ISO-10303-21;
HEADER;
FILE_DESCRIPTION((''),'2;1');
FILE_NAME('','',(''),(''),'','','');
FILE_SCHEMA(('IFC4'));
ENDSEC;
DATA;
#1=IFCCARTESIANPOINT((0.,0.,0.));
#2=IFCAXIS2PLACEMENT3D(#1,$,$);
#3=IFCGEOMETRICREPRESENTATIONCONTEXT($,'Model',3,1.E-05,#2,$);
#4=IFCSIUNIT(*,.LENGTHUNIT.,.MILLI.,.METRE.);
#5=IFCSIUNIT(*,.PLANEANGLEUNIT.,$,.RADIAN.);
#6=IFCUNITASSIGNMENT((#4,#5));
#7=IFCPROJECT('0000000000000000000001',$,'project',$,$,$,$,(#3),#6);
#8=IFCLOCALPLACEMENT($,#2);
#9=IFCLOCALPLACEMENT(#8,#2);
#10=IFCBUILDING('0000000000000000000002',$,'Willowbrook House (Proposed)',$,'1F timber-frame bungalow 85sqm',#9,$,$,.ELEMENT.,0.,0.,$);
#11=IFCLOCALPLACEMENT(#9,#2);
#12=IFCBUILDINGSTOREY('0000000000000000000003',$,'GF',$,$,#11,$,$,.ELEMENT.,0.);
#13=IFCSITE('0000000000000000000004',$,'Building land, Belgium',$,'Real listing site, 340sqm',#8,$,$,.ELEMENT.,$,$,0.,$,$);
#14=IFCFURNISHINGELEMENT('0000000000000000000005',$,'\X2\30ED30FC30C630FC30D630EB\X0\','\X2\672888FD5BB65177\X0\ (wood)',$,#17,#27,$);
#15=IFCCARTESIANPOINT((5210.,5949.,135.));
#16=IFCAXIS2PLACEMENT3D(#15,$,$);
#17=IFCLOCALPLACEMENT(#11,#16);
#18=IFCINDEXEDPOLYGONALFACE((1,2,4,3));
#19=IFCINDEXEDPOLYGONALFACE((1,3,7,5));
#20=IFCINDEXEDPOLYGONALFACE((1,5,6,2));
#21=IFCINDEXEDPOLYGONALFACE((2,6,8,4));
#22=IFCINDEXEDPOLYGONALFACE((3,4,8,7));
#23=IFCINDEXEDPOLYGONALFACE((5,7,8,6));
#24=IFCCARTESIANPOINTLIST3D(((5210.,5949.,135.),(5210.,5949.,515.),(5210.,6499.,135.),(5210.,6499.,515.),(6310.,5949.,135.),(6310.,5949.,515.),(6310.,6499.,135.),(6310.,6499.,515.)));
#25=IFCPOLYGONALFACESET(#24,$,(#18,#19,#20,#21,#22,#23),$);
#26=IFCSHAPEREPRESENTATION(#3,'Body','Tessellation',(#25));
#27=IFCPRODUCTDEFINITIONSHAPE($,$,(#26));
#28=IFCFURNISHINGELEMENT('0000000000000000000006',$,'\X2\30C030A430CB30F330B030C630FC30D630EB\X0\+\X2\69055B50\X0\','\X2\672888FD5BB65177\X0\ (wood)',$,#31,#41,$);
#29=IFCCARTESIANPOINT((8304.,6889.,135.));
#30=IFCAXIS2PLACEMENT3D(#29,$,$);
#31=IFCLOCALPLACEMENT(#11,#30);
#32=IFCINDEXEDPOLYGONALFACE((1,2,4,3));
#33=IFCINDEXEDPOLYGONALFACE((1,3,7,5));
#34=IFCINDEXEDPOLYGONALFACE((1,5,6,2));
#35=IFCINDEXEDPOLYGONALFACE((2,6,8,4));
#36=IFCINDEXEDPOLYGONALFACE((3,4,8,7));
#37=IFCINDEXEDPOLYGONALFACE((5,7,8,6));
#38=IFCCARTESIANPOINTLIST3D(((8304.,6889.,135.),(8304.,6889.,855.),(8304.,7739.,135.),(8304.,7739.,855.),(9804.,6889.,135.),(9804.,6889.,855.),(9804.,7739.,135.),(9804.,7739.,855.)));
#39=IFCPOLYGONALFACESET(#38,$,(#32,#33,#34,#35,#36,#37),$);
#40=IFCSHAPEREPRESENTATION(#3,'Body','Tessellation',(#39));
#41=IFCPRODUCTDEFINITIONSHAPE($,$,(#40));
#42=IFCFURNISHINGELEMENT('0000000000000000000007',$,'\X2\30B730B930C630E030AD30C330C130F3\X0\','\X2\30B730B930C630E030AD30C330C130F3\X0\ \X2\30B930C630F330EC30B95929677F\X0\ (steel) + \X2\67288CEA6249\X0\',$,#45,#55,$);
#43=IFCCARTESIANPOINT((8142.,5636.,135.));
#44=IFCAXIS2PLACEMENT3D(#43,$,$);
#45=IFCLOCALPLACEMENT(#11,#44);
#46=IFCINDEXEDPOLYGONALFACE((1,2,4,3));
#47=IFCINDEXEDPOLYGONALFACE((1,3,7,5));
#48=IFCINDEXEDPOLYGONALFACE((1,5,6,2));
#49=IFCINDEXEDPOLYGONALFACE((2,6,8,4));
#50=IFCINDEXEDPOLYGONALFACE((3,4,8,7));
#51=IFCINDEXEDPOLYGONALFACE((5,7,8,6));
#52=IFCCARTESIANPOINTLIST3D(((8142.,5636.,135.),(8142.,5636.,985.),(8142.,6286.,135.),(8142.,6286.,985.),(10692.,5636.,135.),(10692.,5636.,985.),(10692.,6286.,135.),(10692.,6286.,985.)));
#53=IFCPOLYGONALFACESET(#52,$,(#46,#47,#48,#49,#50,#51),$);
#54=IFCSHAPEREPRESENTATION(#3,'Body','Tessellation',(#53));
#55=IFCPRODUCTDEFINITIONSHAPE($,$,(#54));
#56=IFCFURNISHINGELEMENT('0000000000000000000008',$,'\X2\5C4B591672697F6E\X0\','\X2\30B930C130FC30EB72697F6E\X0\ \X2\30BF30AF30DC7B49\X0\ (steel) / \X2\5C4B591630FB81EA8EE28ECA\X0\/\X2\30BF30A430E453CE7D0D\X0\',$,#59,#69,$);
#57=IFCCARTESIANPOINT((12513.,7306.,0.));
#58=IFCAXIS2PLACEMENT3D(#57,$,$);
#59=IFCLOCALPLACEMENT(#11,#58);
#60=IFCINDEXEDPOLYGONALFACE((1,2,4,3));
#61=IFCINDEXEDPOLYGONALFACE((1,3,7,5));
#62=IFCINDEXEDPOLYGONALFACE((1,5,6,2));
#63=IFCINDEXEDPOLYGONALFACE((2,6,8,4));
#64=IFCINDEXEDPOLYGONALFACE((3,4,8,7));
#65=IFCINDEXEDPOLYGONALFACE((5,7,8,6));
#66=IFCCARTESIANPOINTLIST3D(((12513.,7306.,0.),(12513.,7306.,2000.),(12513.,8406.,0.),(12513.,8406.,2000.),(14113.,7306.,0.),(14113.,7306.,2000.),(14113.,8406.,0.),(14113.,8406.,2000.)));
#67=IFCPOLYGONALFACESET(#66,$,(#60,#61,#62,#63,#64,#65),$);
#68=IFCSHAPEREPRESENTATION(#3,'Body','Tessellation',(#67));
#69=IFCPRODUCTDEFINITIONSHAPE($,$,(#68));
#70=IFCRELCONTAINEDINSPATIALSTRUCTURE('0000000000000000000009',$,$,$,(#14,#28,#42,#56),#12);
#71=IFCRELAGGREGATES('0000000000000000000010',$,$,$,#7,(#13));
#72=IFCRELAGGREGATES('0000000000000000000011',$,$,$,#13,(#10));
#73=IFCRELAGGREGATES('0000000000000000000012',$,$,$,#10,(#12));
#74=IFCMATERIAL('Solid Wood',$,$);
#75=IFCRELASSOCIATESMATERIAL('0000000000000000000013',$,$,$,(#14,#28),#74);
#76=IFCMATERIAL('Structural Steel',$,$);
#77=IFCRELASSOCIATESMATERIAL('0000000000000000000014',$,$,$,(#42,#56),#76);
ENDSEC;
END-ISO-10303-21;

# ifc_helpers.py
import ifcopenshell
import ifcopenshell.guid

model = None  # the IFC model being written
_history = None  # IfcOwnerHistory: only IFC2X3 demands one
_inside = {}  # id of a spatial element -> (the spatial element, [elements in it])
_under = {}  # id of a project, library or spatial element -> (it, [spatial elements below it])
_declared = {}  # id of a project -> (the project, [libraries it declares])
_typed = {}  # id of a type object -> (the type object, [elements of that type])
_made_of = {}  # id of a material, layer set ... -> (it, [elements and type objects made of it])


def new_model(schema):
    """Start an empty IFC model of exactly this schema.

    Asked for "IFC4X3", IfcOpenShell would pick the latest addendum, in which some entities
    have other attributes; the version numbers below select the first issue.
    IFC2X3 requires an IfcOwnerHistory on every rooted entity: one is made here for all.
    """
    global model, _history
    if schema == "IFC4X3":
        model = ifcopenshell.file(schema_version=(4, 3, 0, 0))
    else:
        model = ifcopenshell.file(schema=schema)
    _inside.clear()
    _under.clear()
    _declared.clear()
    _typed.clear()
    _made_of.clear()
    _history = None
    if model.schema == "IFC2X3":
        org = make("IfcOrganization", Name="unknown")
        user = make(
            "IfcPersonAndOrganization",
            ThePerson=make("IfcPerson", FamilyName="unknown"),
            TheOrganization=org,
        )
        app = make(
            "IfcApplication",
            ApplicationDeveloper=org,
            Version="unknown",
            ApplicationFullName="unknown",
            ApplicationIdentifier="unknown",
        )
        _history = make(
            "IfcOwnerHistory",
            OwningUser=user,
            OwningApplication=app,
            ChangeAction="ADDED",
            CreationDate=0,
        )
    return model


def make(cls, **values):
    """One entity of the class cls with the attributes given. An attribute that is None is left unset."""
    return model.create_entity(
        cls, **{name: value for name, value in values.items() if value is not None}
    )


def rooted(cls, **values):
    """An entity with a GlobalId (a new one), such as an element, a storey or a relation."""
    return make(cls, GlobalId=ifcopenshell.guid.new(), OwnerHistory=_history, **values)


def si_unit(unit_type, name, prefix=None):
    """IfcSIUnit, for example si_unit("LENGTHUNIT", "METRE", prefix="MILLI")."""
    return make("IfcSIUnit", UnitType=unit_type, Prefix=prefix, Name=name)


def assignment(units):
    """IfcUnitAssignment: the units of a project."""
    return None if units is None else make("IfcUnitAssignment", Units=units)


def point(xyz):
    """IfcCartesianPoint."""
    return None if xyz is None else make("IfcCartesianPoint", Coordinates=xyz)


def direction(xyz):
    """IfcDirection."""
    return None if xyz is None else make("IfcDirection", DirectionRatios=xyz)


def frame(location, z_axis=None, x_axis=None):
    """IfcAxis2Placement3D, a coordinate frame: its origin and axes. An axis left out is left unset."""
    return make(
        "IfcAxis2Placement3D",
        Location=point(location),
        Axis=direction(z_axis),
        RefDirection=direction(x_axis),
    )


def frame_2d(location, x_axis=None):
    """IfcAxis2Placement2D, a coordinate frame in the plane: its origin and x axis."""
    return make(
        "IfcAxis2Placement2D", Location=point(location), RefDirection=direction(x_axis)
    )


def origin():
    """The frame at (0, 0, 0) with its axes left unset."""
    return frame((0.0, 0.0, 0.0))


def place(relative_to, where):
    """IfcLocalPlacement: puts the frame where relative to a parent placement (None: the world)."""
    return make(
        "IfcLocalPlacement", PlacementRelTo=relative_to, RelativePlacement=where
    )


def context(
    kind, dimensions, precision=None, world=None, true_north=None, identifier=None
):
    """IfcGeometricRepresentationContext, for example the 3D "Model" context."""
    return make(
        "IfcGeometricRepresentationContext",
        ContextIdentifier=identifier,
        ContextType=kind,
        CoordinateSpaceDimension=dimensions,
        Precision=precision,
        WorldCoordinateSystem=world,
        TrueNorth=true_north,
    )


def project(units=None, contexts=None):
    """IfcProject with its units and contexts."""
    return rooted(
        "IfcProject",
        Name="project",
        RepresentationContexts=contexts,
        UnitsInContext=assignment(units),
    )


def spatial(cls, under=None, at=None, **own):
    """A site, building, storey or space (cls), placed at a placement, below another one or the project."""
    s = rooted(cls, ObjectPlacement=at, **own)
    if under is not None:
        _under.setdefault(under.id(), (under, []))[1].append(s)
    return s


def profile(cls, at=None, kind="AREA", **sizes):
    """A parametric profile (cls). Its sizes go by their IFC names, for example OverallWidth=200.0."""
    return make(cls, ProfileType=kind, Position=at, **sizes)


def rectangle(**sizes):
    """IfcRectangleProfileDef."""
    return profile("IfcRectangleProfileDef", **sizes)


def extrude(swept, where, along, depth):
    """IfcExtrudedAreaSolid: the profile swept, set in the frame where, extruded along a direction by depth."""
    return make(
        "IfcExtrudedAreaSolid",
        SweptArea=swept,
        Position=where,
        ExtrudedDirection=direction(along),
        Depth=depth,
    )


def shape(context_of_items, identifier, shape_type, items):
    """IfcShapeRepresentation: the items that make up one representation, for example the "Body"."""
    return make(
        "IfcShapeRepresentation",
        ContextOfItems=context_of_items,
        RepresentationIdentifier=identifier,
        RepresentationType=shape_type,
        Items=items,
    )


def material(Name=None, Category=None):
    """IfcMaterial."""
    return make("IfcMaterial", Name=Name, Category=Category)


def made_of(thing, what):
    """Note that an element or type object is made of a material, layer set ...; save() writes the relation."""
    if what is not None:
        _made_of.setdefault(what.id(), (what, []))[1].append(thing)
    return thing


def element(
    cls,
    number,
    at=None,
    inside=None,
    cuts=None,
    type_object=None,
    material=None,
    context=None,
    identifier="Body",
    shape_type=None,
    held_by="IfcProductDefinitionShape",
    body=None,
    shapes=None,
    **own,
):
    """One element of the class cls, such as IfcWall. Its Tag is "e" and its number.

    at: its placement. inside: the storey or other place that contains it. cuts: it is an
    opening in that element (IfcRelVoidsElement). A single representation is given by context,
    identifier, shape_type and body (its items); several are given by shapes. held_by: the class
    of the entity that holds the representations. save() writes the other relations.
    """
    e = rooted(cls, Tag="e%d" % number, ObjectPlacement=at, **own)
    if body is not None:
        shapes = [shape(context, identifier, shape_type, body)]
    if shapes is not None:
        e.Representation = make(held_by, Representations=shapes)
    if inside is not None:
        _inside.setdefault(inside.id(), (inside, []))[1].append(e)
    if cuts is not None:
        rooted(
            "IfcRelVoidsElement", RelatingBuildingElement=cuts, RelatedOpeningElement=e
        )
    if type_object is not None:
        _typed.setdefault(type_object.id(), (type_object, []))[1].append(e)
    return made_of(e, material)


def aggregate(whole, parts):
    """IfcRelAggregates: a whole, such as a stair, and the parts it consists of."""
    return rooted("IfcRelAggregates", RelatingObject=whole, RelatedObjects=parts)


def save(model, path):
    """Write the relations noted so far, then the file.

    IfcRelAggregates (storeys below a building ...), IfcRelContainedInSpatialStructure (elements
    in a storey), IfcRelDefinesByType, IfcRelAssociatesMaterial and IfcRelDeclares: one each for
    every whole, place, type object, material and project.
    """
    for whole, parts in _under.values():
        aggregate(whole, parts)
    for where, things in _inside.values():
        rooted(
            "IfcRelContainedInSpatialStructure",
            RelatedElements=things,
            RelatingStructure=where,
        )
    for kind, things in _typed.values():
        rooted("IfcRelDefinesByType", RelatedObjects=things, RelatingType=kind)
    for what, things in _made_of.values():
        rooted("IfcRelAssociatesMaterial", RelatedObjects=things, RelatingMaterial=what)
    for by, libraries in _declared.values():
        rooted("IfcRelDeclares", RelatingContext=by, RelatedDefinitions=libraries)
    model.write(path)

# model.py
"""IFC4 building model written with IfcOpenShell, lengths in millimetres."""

from ifc_helpers import new_model, si_unit, frame, frame_2d, origin, place, context, project, spatial, rectangle, extrude, material, element, save


model = new_model("IFC4")

# Units and contexts
model_context = context("Model", 3, precision=1e-05, world=origin())
ifc_project = project(units=[si_unit("LENGTHUNIT", "METRE", prefix="MILLI"), si_unit("PLANEANGLEUNIT", "RADIAN")], contexts=[model_context])

# Site, building, storey
site_placement = place(None, origin())
site = spatial("IfcSite", under=ifc_project, at=site_placement, Name="Building land, Belgium", ObjectType="Real listing site, 340sqm", CompositionType="ELEMENT", RefElevation=0.0)
building_placement = place(site_placement, origin())
building = spatial("IfcBuilding", under=site, at=building_placement, Name="Willowbrook House (Proposed)", ObjectType="1F timber-frame bungalow 85sqm", CompositionType="ELEMENT", ElevationOfRefHeight=0.0, ElevationOfTerrain=0.0)
storey_placement = place(building_placement, origin())
storey = spatial("IfcBuildingStorey", under=building, at=storey_placement, Name="GF", CompositionType="ELEMENT", Elevation=0.0)

# Shared definitions
ifc_material_1 = material(Name="Solid Wood")

# Shared definitions
ifc_material_2 = material(Name="Structural Steel")

# Furnishing elements
furnishing_1_placement = place(storey_placement, frame((5210.0, 5949.0, 135.0)))
element("IfcFurnishingElement", 1, at=furnishing_1_placement, inside=storey, material=ifc_material_1, Name="ローテーブル", Description="木製家具 (wood)", context=model_context, shape_type="SweptSolid", body=[
    extrude(rectangle(XDim=1100.0, YDim=550.0, at=frame_2d((550.0, 275.0))), frame((5210.0, 5949.0, 135.0)), (0.0, 0.0, 1.0), 380.0),
])
furnishing_2_placement = place(storey_placement, frame((8304.0, 6889.0, 135.0)))
element("IfcFurnishingElement", 2, at=furnishing_2_placement, inside=storey, material=ifc_material_1, Name="ダイニングテーブル+椅子", Description="木製家具 (wood)", context=model_context, shape_type="SweptSolid", body=[
    extrude(rectangle(XDim=1500.0, YDim=850.0, at=frame_2d((750.0, 425.0))), frame((8304.0, 6889.0, 135.0)), (0.0, 0.0, 1.0), 720.0),
])
furnishing_3_placement = place(storey_placement, frame((8142.0, 5636.0, 135.0)))
element("IfcFurnishingElement", 3, at=furnishing_3_placement, inside=storey, material=ifc_material_2, Name="システムキッチン", Description="システムキッチン ステンレス天板 (steel) + 木質扉", context=model_context, shape_type="SweptSolid", body=[
    extrude(rectangle(XDim=2550.0, YDim=650.0, at=frame_2d((1275.0, 325.0))), frame((8142.0, 5636.0, 135.0)), (0.0, 0.0, 1.0), 850.0),
])
furnishing_4_placement = place(storey_placement, frame((12513.0, 7306.0, 0.0)))
element("IfcFurnishingElement", 4, at=furnishing_4_placement, inside=storey, material=ifc_material_2, Name="屋外物置", Description="スチール物置 タクボ等 (steel) / 屋外・自転車/タイヤ収納", context=model_context, shape_type="SweptSolid", body=[
    extrude(rectangle(XDim=1600.0, YDim=1100.0, at=frame_2d((800.0, 550.0))), frame((12513.0, 7306.0, 0.0)), (0.0, 0.0, 1.0), 2000.0),
])

save(model, "model.ifc")
